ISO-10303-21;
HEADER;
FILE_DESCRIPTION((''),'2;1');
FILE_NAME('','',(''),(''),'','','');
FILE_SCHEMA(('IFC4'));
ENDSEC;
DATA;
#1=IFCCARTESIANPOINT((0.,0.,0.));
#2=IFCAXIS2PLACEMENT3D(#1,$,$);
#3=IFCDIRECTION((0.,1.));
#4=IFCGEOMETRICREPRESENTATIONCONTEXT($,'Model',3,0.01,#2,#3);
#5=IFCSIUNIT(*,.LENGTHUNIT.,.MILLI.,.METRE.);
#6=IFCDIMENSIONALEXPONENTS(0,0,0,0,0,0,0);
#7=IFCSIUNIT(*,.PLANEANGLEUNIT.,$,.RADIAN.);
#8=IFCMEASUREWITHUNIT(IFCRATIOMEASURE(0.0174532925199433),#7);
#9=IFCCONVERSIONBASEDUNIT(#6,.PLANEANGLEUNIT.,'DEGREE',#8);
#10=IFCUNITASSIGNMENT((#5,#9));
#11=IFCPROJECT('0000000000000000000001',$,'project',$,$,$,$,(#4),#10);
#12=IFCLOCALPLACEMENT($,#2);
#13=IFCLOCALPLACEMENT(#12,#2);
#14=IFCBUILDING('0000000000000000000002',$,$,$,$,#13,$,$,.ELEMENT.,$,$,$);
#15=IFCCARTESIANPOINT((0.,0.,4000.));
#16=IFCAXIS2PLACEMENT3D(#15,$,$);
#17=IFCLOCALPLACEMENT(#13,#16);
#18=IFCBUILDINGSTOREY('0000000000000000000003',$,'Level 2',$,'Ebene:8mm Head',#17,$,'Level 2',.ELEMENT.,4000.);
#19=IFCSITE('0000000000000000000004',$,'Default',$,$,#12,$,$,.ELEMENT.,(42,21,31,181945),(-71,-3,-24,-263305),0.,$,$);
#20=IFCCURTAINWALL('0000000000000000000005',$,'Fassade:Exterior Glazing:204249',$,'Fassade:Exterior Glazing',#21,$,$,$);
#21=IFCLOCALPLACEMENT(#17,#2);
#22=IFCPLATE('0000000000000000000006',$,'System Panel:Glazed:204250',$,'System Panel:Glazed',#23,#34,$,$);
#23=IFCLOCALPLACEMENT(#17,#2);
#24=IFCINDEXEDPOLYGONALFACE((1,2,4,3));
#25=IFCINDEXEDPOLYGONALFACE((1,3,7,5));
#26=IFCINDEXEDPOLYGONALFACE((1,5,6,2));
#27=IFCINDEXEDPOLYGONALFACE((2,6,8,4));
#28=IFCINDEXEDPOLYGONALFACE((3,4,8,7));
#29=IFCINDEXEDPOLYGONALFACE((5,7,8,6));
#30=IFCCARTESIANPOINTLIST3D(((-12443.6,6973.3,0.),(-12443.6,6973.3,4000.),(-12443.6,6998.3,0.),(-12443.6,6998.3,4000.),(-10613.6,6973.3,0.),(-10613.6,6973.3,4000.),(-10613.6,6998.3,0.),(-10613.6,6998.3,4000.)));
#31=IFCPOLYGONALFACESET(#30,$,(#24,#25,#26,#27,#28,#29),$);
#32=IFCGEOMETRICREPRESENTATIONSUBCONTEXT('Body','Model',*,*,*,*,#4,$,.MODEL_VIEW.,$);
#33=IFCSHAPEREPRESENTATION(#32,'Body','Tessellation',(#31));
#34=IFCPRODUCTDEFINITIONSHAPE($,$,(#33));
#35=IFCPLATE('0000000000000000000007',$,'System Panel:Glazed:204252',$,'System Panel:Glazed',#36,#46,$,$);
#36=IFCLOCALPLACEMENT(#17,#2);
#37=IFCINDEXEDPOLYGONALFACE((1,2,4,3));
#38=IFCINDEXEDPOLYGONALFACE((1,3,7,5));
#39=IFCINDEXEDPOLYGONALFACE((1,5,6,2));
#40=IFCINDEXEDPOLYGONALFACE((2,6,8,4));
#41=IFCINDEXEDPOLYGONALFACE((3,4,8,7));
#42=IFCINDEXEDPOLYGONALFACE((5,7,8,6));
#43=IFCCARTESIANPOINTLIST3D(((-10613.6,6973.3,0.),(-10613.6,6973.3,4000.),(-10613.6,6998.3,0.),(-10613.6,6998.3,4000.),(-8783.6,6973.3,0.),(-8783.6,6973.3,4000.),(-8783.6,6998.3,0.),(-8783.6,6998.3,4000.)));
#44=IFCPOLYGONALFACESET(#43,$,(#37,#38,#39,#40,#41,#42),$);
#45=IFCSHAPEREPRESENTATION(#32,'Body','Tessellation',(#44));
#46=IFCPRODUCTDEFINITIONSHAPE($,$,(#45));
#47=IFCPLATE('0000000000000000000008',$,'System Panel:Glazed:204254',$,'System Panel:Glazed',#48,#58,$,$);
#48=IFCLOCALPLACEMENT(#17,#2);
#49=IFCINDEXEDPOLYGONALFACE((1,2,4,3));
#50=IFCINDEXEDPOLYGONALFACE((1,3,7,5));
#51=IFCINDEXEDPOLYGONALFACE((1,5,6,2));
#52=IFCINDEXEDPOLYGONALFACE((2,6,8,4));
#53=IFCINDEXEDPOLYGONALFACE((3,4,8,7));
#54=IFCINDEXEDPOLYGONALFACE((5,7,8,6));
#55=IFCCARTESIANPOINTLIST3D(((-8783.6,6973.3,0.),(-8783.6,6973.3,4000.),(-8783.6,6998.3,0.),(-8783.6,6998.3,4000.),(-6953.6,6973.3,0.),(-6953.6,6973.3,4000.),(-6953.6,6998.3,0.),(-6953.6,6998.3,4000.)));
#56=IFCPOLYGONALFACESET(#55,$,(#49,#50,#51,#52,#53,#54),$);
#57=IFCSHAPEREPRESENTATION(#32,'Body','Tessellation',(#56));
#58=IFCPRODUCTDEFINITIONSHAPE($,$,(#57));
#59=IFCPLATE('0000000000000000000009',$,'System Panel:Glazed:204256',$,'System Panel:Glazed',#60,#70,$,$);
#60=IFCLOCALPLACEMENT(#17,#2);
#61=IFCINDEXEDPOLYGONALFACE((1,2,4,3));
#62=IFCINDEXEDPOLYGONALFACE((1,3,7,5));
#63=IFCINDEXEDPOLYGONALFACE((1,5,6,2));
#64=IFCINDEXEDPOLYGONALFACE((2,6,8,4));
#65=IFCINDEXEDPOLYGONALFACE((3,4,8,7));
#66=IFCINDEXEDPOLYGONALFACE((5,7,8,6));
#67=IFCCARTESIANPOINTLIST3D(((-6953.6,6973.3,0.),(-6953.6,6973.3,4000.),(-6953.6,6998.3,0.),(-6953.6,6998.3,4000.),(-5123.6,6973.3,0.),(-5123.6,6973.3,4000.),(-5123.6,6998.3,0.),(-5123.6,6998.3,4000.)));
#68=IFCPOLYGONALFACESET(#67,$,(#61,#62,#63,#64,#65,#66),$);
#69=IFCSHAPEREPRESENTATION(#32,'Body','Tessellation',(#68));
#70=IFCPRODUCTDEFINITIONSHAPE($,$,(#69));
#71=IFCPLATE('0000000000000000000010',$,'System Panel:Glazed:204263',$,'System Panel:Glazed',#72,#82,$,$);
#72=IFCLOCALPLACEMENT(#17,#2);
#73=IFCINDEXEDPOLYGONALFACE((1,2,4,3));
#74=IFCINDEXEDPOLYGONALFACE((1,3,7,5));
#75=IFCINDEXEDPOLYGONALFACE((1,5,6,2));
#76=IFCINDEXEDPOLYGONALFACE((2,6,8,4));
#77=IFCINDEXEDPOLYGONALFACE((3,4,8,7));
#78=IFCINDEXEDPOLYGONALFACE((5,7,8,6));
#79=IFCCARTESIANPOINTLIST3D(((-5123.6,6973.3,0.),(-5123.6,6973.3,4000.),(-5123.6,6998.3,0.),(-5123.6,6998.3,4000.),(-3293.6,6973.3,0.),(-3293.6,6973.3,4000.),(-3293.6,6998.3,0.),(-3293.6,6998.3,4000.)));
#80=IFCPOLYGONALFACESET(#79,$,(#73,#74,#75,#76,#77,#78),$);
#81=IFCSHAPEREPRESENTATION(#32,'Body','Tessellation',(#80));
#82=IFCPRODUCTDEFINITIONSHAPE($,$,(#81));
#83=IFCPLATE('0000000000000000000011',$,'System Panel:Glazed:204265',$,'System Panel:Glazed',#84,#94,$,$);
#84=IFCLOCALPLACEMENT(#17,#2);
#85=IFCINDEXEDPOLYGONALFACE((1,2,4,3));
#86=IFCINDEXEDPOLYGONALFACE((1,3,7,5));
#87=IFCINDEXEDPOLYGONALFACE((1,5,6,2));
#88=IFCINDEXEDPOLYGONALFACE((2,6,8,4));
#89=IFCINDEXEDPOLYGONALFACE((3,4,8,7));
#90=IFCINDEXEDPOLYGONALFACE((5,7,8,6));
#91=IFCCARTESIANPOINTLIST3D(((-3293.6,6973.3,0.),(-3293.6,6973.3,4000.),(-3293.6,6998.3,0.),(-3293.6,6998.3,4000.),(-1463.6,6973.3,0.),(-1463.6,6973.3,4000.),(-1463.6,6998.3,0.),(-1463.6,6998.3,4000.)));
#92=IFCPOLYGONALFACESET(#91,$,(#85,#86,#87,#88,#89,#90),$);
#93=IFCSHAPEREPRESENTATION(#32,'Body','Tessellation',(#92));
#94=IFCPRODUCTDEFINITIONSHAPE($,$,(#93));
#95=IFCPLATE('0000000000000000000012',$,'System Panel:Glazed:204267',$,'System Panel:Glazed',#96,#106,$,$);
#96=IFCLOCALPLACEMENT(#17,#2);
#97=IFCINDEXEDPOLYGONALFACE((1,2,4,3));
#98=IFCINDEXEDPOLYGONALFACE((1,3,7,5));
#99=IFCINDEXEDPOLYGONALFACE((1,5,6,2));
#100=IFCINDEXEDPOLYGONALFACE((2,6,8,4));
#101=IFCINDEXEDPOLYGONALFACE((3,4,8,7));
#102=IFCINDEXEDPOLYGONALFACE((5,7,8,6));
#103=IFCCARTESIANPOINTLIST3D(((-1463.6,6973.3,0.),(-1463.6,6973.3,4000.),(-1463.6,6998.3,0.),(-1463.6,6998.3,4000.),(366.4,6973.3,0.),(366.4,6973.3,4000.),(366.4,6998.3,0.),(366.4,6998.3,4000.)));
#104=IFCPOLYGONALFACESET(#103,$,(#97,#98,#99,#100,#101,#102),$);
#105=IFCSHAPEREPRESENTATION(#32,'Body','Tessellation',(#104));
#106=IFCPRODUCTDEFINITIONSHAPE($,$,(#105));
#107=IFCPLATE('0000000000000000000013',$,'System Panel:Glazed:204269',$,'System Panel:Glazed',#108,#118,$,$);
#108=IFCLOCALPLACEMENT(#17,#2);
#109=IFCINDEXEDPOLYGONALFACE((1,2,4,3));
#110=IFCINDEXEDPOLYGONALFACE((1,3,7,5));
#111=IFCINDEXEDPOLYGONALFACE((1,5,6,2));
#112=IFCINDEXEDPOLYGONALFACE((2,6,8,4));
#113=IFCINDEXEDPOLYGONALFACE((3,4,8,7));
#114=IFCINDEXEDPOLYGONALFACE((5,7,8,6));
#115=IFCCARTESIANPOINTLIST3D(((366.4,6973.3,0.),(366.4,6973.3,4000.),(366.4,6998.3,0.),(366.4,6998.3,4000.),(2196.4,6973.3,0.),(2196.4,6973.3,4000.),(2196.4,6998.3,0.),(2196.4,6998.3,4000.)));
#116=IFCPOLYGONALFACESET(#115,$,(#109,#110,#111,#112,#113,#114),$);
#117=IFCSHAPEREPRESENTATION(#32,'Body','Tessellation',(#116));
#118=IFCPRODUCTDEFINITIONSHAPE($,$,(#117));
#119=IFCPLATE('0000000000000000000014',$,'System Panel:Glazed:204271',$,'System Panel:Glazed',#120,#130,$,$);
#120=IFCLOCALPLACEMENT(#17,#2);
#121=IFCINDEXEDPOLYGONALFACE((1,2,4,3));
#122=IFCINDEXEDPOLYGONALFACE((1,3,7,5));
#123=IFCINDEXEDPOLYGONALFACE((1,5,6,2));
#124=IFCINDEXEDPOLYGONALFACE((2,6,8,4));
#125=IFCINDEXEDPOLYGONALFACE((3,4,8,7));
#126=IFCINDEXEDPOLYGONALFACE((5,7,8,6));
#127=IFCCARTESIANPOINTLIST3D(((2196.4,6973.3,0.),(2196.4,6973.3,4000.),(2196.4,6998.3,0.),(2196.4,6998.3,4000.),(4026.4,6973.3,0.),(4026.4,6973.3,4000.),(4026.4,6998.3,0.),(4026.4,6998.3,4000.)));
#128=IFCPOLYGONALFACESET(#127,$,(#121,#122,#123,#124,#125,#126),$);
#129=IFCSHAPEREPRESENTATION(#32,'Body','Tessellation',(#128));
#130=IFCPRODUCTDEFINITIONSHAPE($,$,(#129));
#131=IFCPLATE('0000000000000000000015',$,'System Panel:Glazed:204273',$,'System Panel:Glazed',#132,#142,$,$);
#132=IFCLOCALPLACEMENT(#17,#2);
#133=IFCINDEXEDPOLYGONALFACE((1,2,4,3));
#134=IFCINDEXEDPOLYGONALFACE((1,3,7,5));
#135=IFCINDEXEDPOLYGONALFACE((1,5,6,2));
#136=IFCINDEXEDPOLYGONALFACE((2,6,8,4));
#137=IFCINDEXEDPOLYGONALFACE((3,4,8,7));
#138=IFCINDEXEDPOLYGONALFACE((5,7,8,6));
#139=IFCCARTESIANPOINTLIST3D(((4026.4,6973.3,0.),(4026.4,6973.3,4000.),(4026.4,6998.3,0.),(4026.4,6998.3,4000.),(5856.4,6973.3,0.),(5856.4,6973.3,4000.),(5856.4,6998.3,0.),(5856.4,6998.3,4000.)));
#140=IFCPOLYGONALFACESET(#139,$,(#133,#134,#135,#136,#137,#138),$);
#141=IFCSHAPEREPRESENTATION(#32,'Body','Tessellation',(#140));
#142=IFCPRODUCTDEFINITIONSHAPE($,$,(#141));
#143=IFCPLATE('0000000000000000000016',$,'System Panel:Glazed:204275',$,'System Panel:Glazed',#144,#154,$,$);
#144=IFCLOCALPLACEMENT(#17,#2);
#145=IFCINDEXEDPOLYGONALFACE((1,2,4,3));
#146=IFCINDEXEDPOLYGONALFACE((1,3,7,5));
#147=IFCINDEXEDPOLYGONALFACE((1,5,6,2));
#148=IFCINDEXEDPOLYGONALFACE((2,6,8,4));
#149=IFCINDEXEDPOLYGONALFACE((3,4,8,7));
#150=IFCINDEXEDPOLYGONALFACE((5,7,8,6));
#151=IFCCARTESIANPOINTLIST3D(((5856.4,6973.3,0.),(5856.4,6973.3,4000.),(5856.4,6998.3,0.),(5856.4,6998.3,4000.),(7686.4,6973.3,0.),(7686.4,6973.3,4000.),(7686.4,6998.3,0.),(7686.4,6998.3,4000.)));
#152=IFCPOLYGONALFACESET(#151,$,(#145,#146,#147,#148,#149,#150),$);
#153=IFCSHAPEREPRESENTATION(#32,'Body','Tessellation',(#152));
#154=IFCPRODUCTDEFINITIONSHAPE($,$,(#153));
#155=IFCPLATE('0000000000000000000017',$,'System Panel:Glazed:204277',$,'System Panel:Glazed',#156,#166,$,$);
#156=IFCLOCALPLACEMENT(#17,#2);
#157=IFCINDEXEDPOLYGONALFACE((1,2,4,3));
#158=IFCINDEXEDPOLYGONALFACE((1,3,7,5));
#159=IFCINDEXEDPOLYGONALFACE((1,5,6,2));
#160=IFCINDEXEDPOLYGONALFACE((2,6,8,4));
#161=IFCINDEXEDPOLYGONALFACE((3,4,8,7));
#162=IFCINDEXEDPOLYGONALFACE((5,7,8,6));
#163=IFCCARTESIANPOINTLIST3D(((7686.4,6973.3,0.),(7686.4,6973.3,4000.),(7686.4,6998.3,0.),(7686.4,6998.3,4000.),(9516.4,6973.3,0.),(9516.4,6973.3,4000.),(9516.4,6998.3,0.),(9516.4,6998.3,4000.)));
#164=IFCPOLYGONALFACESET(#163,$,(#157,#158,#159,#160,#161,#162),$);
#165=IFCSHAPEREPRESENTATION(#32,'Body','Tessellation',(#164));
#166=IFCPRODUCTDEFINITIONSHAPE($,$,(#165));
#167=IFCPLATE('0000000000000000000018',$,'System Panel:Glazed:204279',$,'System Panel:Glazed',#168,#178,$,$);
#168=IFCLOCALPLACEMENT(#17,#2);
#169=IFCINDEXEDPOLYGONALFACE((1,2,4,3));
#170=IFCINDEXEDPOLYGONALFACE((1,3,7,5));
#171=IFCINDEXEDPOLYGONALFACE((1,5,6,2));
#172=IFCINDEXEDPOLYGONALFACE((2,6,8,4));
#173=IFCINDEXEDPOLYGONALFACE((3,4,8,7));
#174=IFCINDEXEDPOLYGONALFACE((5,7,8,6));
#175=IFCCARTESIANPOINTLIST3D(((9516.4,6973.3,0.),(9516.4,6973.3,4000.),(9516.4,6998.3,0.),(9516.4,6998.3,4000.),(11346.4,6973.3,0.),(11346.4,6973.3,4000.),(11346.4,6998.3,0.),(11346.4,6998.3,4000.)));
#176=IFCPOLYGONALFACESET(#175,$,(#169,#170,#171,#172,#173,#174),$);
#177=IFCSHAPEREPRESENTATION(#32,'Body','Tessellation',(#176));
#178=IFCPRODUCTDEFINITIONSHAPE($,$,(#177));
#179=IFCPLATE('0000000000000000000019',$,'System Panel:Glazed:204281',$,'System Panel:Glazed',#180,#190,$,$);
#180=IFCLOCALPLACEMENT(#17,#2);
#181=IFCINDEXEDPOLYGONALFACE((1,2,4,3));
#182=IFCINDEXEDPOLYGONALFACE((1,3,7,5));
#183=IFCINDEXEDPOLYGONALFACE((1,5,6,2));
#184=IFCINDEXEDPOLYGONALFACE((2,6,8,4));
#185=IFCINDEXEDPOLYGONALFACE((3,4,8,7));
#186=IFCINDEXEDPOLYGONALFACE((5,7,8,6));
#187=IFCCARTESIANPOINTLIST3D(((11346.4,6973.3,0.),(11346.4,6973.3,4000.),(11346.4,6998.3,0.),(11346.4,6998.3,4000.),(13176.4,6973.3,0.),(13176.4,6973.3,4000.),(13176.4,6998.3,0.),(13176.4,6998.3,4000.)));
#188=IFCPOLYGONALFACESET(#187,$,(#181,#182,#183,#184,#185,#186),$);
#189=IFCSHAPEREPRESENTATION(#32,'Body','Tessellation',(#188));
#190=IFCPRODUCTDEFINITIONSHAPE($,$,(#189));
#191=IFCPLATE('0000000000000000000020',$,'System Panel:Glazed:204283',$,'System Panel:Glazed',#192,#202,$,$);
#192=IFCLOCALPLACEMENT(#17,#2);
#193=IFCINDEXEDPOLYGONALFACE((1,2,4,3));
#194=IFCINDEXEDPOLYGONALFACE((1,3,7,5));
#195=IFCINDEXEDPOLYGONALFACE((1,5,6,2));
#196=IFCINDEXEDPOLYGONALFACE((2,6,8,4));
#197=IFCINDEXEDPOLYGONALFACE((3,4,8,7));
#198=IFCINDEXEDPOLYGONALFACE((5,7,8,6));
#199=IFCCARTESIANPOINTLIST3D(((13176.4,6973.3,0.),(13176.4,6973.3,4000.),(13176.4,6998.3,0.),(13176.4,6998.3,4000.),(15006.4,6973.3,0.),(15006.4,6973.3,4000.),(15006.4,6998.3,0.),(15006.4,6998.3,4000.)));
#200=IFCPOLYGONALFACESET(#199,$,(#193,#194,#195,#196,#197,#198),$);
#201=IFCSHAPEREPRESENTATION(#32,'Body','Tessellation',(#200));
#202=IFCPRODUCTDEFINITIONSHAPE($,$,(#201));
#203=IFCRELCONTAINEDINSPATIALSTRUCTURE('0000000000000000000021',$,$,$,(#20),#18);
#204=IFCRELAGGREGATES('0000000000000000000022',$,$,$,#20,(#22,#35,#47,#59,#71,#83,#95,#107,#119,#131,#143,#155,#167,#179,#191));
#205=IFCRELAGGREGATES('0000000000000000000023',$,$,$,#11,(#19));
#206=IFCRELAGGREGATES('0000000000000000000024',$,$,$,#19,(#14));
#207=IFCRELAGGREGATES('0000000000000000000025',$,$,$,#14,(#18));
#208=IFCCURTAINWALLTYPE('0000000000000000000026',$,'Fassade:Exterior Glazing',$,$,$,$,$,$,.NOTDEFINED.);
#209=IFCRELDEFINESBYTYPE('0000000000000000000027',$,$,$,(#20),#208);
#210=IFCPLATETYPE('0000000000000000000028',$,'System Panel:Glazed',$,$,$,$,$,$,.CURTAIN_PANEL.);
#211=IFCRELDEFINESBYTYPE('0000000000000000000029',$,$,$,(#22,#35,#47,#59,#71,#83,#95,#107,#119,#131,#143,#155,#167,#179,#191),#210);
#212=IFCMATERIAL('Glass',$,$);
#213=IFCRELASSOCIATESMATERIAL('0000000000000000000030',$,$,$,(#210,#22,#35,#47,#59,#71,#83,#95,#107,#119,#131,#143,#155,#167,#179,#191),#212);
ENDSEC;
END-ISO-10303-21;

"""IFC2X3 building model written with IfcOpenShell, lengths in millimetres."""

from ifc_helpers import new_model, entity, si_unit, converted_unit, direction, frame, origin, origin_2d_with_axis, place, context, subcontext, project, spatial, rectangle, extrude, source, transform, mapped, material, type_object, type_shapes, element, aggregate, save


model = new_model("IFC2X3")

# Units and contexts
model_context = context("Model", 3, precision=0.01, world=origin(), true_north=direction((0.0, 1.0)))
body_context = subcontext(model_context, "Body", "Model", "MODEL_VIEW")
ifc_project = project(units=[si_unit("LENGTHUNIT", "METRE", prefix="MILLI"), converted_unit("PLANEANGLEUNIT", "DEGREE", entity("IfcRatioMeasure", 0.0174532925199433), si_unit("PLANEANGLEUNIT", "RADIAN"), dimensions=[0, 0, 0, 0, 0, 0, 0])], contexts=[model_context])

# Site, building, storey
site_placement = place(None, origin())
site = spatial("IfcSite", under=ifc_project, at=site_placement, Name="Default", CompositionType="ELEMENT", RefLatitude=(42, 21, 31, 181945), RefLongitude=(-71, -3, -24, -263305), RefElevation=0.0)
building_placement = place(site_placement, origin())
building = spatial("IfcBuilding", under=site, at=building_placement, CompositionType="ELEMENT")
storey_placement = place(building_placement, frame((0.0, 0.0, 4000.0)))
storey = spatial("IfcBuildingStorey", under=building, at=storey_placement, Name="Level 2", ObjectType="Ebene:8mm Head", LongName="Level 2", CompositionType="ELEMENT", Elevation=4000.0)

# Curtain wall, plates
curtain_wall_type = type_object("IfcCurtainWallType", Name="Fassade:Exterior Glazing", PredefinedType="NOTDEFINED")
curtain_wall_placement = place(storey_placement, frame((0.0, 0.0, -4000.0)))
curtain_wall = element("IfcCurtainWall", 1, at=curtain_wall_placement, inside=storey, type_object=curtain_wall_type, Name="Fassade:Exterior Glazing:204249", ObjectType="Fassade:Exterior Glazing")
ifc_material_1 = material(Name="Glass")
plate_type_1 = type_object("IfcPlateType", Name="System Panel:Glazed", PredefinedType="CURTAIN_PANEL", material=ifc_material_1)
shared_shape_1 = source(origin(), body_context, "Body", "SweptSolid", [
    extrude(rectangle(XDim=25.0, YDim=1830.0, at=origin_2d_with_axis()), frame((0.0, 37.0, 0.0), z_axis=(0.0, 0.0, 1.0), x_axis=(0.0, 1.0, 0.0)), (0.0, 0.0, 1.0), 4000.0),
])
type_shapes(plate_type_1, [shared_shape_1])
plate_1_placement = place(curtain_wall_placement, frame((-11528.6, 6948.8, 4000.0)))
plate_1 = element("IfcPlate", 2, at=plate_1_placement, type_object=plate_type_1, material=ifc_material_1, Name="System Panel:Glazed:204250", ObjectType="System Panel:Glazed", context=body_context, shape_type="MappedRepresentation", body=[
    mapped(shared_shape_1, transform((0.0, 0.0, 0.0), scale=1.0)),
])
plate_2_placement = place(curtain_wall_placement, frame((-9698.6, 6948.8, 4000.0)))
plate_2 = element("IfcPlate", 3, at=plate_2_placement, type_object=plate_type_1, material=ifc_material_1, Name="System Panel:Glazed:204252", ObjectType="System Panel:Glazed", context=body_context, shape_type="MappedRepresentation", body=[
    mapped(shared_shape_1, transform((0.0, 0.0, 0.0), scale=1.0)),
])
plate_3_placement = place(curtain_wall_placement, frame((-7868.6, 6948.8, 4000.0)))
plate_3 = element("IfcPlate", 4, at=plate_3_placement, type_object=plate_type_1, material=ifc_material_1, Name="System Panel:Glazed:204254", ObjectType="System Panel:Glazed", context=body_context, shape_type="MappedRepresentation", body=[
    mapped(shared_shape_1, transform((0.0, 0.0, 0.0), scale=1.0)),
])
plate_4_placement = place(curtain_wall_placement, frame((-6038.6, 6948.8, 4000.0)))
plate_4 = element("IfcPlate", 5, at=plate_4_placement, type_object=plate_type_1, material=ifc_material_1, Name="System Panel:Glazed:204256", ObjectType="System Panel:Glazed", context=body_context, shape_type="MappedRepresentation", body=[
    mapped(shared_shape_1, transform((0.0, 0.0, 0.0), scale=1.0)),
])
plate_5_placement = place(curtain_wall_placement, frame((-4208.6, 6948.8, 4000.0)))
plate_5 = element("IfcPlate", 6, at=plate_5_placement, type_object=plate_type_1, material=ifc_material_1, Name="System Panel:Glazed:204263", ObjectType="System Panel:Glazed", context=body_context, shape_type="MappedRepresentation", body=[
    mapped(shared_shape_1, transform((0.0, 0.0, 0.0), scale=1.0)),
])
plate_6_placement = place(curtain_wall_placement, frame((-2378.6, 6948.8, 4000.0)))
plate_6 = element("IfcPlate", 7, at=plate_6_placement, type_object=plate_type_1, material=ifc_material_1, Name="System Panel:Glazed:204265", ObjectType="System Panel:Glazed", context=body_context, shape_type="MappedRepresentation", body=[
    mapped(shared_shape_1, transform((0.0, 0.0, 0.0), scale=1.0)),
])
plate_7_placement = place(curtain_wall_placement, frame((-548.6, 6948.8, 4000.0)))
plate_7 = element("IfcPlate", 8, at=plate_7_placement, type_object=plate_type_1, material=ifc_material_1, Name="System Panel:Glazed:204267", ObjectType="System Panel:Glazed", context=body_context, shape_type="MappedRepresentation", body=[
    mapped(shared_shape_1, transform((0.0, 0.0, 0.0), scale=1.0)),
])
plate_8_placement = place(curtain_wall_placement, frame((1281.4, 6948.8, 4000.0)))
plate_8 = element("IfcPlate", 9, at=plate_8_placement, type_object=plate_type_1, material=ifc_material_1, Name="System Panel:Glazed:204269", ObjectType="System Panel:Glazed", context=body_context, shape_type="MappedRepresentation", body=[
    mapped(shared_shape_1, transform((0.0, 0.0, 0.0), scale=1.0)),
])
plate_9_placement = place(curtain_wall_placement, frame((3111.4, 6948.8, 4000.0)))
plate_9 = element("IfcPlate", 10, at=plate_9_placement, type_object=plate_type_1, material=ifc_material_1, Name="System Panel:Glazed:204271", ObjectType="System Panel:Glazed", context=body_context, shape_type="MappedRepresentation", body=[
    mapped(shared_shape_1, transform((0.0, 0.0, 0.0), scale=1.0)),
])
plate_10_placement = place(curtain_wall_placement, frame((4941.4, 6948.8, 4000.0)))
plate_10 = element("IfcPlate", 11, at=plate_10_placement, type_object=plate_type_1, material=ifc_material_1, Name="System Panel:Glazed:204273", ObjectType="System Panel:Glazed", context=body_context, shape_type="MappedRepresentation", body=[
    mapped(shared_shape_1, transform((0.0, 0.0, 0.0), scale=1.0)),
])
plate_11_placement = place(curtain_wall_placement, frame((6771.4, 6948.8, 4000.0)))
plate_11 = element("IfcPlate", 12, at=plate_11_placement, type_object=plate_type_1, material=ifc_material_1, Name="System Panel:Glazed:204275", ObjectType="System Panel:Glazed", context=body_context, shape_type="MappedRepresentation", body=[
    mapped(shared_shape_1, transform((0.0, 0.0, 0.0), scale=1.0)),
])
plate_12_placement = place(curtain_wall_placement, frame((8601.4, 6948.8, 4000.0)))
plate_12 = element("IfcPlate", 13, at=plate_12_placement, type_object=plate_type_1, material=ifc_material_1, Name="System Panel:Glazed:204277", ObjectType="System Panel:Glazed", context=body_context, shape_type="MappedRepresentation", body=[
    mapped(shared_shape_1, transform((0.0, 0.0, 0.0), scale=1.0)),
])
plate_13_placement = place(curtain_wall_placement, frame((10431.4, 6948.8, 4000.0)))
plate_13 = element("IfcPlate", 14, at=plate_13_placement, type_object=plate_type_1, material=ifc_material_1, Name="System Panel:Glazed:204279", ObjectType="System Panel:Glazed", context=body_context, shape_type="MappedRepresentation", body=[
    mapped(shared_shape_1, transform((0.0, 0.0, 0.0), scale=1.0)),
])
plate_14_placement = place(curtain_wall_placement, frame((12261.4, 6948.8, 4000.0)))
plate_14 = element("IfcPlate", 15, at=plate_14_placement, type_object=plate_type_1, material=ifc_material_1, Name="System Panel:Glazed:204281", ObjectType="System Panel:Glazed", context=body_context, shape_type="MappedRepresentation", body=[
    mapped(shared_shape_1, transform((0.0, 0.0, 0.0), scale=1.0)),
])
plate_15_placement = place(curtain_wall_placement, frame((14091.4, 6948.8, 4000.0)))
plate_15 = element("IfcPlate", 16, at=plate_15_placement, type_object=plate_type_1, material=ifc_material_1, Name="System Panel:Glazed:204283", ObjectType="System Panel:Glazed", context=body_context, shape_type="MappedRepresentation", body=[
    mapped(shared_shape_1, transform((0.0, 0.0, 0.0), scale=1.0)),
])
aggregate(curtain_wall, [plate_1, plate_2, plate_3, plate_4, plate_5, plate_6, plate_7, plate_8, plate_9, plate_10, plate_11, plate_12, plate_13, plate_14, plate_15])

save(model, "model.ifc")
